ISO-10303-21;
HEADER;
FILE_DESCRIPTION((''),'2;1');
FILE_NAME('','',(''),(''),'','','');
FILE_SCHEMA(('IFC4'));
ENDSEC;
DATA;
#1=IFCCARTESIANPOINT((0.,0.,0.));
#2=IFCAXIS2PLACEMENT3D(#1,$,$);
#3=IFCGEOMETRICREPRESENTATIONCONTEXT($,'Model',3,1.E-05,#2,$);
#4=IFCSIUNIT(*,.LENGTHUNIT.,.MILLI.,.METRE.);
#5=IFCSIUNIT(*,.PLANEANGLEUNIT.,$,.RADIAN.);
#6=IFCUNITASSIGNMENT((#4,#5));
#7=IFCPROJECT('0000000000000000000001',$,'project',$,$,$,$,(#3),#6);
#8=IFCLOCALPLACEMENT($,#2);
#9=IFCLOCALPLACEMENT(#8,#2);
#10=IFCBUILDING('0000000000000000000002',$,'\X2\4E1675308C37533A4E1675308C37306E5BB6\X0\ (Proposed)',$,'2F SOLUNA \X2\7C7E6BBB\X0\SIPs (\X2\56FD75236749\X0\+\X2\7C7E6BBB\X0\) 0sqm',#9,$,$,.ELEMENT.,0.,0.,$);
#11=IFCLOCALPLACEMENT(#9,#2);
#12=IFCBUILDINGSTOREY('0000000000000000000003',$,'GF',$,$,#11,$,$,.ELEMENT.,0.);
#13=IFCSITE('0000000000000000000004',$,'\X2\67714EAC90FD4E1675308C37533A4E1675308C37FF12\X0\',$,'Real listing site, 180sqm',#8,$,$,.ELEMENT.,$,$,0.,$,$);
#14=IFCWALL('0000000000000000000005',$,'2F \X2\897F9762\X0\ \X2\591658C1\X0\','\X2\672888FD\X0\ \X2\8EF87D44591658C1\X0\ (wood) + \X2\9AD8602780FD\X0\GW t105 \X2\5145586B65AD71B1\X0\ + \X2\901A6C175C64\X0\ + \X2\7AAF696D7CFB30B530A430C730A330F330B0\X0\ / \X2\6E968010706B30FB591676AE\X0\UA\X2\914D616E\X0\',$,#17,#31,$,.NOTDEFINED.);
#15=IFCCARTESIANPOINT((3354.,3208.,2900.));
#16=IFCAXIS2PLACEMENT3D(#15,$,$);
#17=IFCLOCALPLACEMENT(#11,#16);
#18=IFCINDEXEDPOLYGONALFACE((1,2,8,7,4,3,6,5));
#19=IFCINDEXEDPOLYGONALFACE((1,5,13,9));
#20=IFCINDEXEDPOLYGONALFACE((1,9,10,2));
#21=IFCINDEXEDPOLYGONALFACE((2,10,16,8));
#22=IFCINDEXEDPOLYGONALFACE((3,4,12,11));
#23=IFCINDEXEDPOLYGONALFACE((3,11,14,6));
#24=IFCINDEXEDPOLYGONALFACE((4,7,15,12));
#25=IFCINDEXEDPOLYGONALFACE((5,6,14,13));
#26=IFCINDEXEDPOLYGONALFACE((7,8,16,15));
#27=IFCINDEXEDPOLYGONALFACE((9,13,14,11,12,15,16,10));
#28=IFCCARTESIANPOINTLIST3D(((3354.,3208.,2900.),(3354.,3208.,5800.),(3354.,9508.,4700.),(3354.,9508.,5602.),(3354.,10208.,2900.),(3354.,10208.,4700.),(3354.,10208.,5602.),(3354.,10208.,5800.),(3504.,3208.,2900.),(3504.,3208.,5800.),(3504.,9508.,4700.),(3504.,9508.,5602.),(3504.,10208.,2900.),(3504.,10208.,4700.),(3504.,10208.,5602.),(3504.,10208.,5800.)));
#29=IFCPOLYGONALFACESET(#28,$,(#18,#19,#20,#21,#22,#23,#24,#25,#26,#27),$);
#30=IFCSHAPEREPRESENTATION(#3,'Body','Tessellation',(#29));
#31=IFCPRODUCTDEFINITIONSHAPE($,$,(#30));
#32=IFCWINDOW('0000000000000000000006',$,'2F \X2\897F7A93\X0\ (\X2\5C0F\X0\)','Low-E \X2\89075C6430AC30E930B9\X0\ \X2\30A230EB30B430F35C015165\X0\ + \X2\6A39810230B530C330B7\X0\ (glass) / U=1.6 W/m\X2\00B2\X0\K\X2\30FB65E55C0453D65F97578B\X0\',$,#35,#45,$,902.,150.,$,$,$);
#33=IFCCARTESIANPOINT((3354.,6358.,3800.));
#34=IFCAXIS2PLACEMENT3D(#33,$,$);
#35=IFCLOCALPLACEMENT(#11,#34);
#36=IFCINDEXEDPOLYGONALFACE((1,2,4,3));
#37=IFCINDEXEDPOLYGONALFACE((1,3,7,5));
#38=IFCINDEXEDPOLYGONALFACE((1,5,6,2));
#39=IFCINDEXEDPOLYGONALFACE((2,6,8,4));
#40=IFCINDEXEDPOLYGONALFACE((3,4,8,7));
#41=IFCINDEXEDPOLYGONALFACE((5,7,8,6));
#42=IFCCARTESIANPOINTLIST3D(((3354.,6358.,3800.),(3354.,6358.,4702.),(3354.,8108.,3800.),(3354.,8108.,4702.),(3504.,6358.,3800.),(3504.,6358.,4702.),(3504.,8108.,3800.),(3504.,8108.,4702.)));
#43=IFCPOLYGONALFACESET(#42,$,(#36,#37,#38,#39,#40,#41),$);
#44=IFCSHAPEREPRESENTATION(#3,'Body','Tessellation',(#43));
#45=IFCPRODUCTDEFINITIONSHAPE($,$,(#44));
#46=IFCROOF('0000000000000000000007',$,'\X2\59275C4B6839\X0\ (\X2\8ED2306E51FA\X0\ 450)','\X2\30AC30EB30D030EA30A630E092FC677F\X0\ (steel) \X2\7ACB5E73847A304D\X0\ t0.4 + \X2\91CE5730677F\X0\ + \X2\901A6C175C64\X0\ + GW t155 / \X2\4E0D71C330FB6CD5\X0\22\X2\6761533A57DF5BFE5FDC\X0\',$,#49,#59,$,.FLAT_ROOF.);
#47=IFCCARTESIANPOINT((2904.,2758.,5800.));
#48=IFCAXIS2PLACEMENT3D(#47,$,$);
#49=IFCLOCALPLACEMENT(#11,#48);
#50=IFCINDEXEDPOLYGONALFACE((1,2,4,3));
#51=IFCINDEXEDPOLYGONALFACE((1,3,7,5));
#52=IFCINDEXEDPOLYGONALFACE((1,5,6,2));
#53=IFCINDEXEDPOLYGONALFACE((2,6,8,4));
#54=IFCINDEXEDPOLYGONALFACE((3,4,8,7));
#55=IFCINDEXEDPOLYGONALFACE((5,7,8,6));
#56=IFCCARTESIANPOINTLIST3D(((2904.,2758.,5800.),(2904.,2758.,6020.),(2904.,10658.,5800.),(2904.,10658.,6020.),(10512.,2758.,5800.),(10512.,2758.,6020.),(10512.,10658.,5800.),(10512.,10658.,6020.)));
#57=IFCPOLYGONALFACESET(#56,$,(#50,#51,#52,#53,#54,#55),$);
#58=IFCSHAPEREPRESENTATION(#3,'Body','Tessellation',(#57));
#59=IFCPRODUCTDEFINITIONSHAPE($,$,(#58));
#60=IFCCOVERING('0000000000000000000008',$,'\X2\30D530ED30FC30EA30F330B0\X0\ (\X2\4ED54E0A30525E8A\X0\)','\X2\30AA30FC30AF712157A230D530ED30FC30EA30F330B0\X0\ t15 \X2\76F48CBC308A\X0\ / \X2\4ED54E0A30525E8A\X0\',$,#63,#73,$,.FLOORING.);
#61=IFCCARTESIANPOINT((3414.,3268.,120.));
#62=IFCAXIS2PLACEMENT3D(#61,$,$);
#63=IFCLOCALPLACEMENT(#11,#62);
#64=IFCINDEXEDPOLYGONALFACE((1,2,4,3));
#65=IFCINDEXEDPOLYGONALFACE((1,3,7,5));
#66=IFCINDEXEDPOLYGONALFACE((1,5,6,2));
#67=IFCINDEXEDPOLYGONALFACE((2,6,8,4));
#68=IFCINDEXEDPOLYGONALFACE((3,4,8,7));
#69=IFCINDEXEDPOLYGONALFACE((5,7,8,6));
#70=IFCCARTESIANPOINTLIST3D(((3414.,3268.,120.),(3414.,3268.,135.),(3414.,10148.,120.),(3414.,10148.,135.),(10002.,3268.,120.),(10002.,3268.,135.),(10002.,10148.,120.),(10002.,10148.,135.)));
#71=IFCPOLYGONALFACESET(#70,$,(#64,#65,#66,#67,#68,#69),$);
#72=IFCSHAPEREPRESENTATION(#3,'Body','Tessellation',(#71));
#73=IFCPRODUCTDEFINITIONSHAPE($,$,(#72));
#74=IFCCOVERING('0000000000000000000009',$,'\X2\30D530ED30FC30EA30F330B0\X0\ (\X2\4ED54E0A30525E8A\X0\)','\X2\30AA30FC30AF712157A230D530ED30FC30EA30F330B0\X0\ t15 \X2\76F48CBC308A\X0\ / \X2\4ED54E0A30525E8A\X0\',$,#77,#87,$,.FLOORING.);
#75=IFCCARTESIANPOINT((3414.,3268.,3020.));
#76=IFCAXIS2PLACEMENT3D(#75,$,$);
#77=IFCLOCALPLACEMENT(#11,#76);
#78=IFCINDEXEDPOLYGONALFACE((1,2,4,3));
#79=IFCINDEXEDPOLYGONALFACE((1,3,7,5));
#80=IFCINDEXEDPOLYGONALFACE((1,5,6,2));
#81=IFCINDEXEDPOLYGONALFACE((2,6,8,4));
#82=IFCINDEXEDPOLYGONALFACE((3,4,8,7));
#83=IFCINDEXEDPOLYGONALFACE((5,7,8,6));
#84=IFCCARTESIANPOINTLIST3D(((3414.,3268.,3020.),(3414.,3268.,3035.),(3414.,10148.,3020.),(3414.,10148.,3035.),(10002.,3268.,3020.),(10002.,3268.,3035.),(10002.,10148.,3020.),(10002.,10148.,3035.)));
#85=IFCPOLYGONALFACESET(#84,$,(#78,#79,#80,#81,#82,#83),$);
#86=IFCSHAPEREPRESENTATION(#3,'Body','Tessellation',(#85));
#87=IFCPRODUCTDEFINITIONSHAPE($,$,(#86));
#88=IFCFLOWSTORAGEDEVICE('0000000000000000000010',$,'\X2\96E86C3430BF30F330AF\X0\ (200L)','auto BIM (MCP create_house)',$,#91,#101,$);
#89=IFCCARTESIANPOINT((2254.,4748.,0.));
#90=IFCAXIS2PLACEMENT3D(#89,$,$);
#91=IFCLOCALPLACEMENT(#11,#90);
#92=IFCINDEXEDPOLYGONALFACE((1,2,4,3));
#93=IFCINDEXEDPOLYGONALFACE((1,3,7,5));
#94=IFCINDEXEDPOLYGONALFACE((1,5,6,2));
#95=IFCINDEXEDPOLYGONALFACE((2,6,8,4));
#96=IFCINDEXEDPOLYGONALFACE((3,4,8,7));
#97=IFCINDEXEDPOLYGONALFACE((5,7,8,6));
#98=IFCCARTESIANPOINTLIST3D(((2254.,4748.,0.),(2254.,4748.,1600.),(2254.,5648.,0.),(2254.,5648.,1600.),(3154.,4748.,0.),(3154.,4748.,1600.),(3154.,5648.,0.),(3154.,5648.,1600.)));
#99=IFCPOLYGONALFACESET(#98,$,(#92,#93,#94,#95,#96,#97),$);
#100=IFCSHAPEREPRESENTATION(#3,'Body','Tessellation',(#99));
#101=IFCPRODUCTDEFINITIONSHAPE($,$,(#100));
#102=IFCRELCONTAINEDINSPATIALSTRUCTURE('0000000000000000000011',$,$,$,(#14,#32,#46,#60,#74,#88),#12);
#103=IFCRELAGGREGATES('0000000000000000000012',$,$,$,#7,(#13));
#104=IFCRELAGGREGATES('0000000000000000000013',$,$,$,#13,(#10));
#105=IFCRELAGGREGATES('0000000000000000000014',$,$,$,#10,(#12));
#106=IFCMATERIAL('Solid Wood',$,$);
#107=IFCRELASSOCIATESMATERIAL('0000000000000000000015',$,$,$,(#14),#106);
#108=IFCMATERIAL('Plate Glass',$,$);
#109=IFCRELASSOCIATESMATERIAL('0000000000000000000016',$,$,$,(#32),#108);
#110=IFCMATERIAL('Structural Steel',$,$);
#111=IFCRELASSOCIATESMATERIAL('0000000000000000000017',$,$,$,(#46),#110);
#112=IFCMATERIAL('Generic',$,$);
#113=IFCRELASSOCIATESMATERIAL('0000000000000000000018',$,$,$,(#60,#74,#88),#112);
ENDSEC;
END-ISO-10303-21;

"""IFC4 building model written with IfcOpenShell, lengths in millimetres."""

from ifc_helpers import new_model, si_unit, frame, frame_2d, origin, place, context, project, spatial, rectangle, extrude, material, element, fill, save


model = new_model("IFC4")

# Units and contexts
model_context = context("Model", 3, precision=1e-05, world=origin())
ifc_project = project(units=[si_unit("LENGTHUNIT", "METRE", prefix="MILLI"), si_unit("PLANEANGLEUNIT", "RADIAN")], contexts=[model_context])

# Site, building, storey
site_placement = place(None, origin())
site = spatial("IfcSite", under=ifc_project, at=site_placement, Name="東京都世田谷区世田谷２", ObjectType="Real listing site, 180sqm", CompositionType="ELEMENT", RefElevation=0.0)
building_placement = place(site_placement, origin())
building = spatial("IfcBuilding", under=site, at=building_placement, Name="世田谷区世田谷の家 (Proposed)", ObjectType="2F SOLUNA 籾殻SIPs (国産杉+籾殻) 0sqm", CompositionType="ELEMENT", ElevationOfRefHeight=0.0, ElevationOfTerrain=0.0)
storey_placement = place(building_placement, origin())
storey = spatial("IfcBuildingStorey", under=building, at=storey_placement, Name="GF", CompositionType="ELEMENT", Elevation=0.0)

# Shared definitions
ifc_material_1 = material(Name="Solid Wood")

# Shared definitions
ifc_material_2 = material(Name="Plate Glass")

# Wall, opening, window
wall_1_placement = place(storey_placement, frame((3354.0, 3208.0, 2900.0)))
wall_1 = element("IfcWall", 1, at=wall_1_placement, inside=storey, material=ifc_material_1, Name="2F 西面 外壁", Description="木製 軸組外壁 (wood) + 高性能GW t105 充填断熱 + 通気層 + 窯業系サイディング / 準耐火・外皮UA配慮", PredefinedType="NOTDEFINED", context=model_context, shape_type="SweptSolid", body=[
    extrude(rectangle(XDim=150.0, YDim=7000.0, at=frame_2d((75.0, 3500.0))), frame((3354.0, 3208.0, 2900.0)), (0.0, 0.0, 1.0), 2900.0),
])
opening_1_placement = place(storey_placement, frame((3354.0, 6358.0, 3800.0)))
opening_1 = element("IfcOpeningElement", 2, at=opening_1_placement, cuts=wall_1, PredefinedType="NOTDEFINED", context=model_context, shape_type="SweptSolid", body=[
    extrude(rectangle(XDim=150.0, YDim=1750.0, at=frame_2d((75.0, 875.0))), frame((3354.0, 6358.0, 3800.0)), (0.0, 0.0, 1.0), 902.0),
])
window_1_placement = place(storey_placement, frame((3354.0, 6358.0, 3800.0)))
window_1 = element("IfcWindow", 3, at=window_1_placement, inside=storey, material=ifc_material_2, Name="2F 西窓 (小)", Description="Low-E 複層ガラス アルゴン封入 + 樹脂サッシ (glass) / U=1.6 W/m²K・日射取得型", OverallHeight=902.0, OverallWidth=150.0, context=model_context, shape_type="SweptSolid", body=[
    extrude(rectangle(XDim=150.0, YDim=1750.0, at=frame_2d((75.0, 875.0))), frame((3354.0, 6358.0, 3800.0)), (0.0, 0.0, 1.0), 902.0),
])
fill(opening_1, window_1)

# Roof
ifc_material_3 = material(Name="Structural Steel")
roof_placement = place(storey_placement, frame((2904.0, 2758.0, 5800.0)))
element("IfcRoof", 4, at=roof_placement, inside=storey, material=ifc_material_3, Name="大屋根 (軒の出 450)", Description="ガルバリウム鋼板 (steel) 立平葺き t0.4 + 野地板 + 通気層 + GW t155 / 不燃・法22条区域対応", PredefinedType="FLAT_ROOF", context=model_context, shape_type="SweptSolid", body=[
    extrude(rectangle(XDim=7608.0, YDim=7900.0, at=frame_2d((3804.0, 3950.0))), frame((2904.0, 2758.0, 5800.0)), (0.0, 0.0, 1.0), 220.0),
])

# Coverings
ifc_material_4 = material(Name="Generic")
covering_1_placement = place(storey_placement, frame((3414.0, 3268.0, 120.0)))
element("IfcCovering", 5, at=covering_1_placement, inside=storey, material=ifc_material_4, Name="フローリング (仕上げ床)", Description="オーク無垢フローリング t15 直貼り / 仕上げ床", PredefinedType="FLOORING", context=model_context, shape_type="SweptSolid", body=[
    extrude(rectangle(XDim=6588.0, YDim=6880.0, at=frame_2d((3294.0, 3440.0))), frame((3414.0, 3268.0, 120.0)), (0.0, 0.0, 1.0), 15.0),
])
covering_2_placement = place(storey_placement, frame((3414.0, 3268.0, 3020.0)))
element("IfcCovering", 6, at=covering_2_placement, inside=storey, material=ifc_material_4, Name="フローリング (仕上げ床)", Description="オーク無垢フローリング t15 直貼り / 仕上げ床", PredefinedType="FLOORING", context=model_context, shape_type="SweptSolid", body=[
    extrude(rectangle(XDim=6588.0, YDim=6880.0, at=frame_2d((3294.0, 3440.0))), frame((3414.0, 3268.0, 3020.0)), (0.0, 0.0, 1.0), 15.0),
])

# Flow storage device
flow_storage_device_placement = place(storey_placement, frame((2254.0, 4748.0, 0.0)))
element("IfcFlowStorageDevice", 7, at=flow_storage_device_placement, inside=storey, material=ifc_material_4, Name="雨水タンク (200L)", Description="auto BIM (MCP create_house)", context=model_context, shape_type="SweptSolid", body=[
    extrude(rectangle(XDim=900.0, YDim=900.0, at=frame_2d((450.0, 450.0))), frame((2254.0, 4748.0, 0.0)), (0.0, 0.0, 1.0), 1600.0),
])

save(model, "model.ifc")
